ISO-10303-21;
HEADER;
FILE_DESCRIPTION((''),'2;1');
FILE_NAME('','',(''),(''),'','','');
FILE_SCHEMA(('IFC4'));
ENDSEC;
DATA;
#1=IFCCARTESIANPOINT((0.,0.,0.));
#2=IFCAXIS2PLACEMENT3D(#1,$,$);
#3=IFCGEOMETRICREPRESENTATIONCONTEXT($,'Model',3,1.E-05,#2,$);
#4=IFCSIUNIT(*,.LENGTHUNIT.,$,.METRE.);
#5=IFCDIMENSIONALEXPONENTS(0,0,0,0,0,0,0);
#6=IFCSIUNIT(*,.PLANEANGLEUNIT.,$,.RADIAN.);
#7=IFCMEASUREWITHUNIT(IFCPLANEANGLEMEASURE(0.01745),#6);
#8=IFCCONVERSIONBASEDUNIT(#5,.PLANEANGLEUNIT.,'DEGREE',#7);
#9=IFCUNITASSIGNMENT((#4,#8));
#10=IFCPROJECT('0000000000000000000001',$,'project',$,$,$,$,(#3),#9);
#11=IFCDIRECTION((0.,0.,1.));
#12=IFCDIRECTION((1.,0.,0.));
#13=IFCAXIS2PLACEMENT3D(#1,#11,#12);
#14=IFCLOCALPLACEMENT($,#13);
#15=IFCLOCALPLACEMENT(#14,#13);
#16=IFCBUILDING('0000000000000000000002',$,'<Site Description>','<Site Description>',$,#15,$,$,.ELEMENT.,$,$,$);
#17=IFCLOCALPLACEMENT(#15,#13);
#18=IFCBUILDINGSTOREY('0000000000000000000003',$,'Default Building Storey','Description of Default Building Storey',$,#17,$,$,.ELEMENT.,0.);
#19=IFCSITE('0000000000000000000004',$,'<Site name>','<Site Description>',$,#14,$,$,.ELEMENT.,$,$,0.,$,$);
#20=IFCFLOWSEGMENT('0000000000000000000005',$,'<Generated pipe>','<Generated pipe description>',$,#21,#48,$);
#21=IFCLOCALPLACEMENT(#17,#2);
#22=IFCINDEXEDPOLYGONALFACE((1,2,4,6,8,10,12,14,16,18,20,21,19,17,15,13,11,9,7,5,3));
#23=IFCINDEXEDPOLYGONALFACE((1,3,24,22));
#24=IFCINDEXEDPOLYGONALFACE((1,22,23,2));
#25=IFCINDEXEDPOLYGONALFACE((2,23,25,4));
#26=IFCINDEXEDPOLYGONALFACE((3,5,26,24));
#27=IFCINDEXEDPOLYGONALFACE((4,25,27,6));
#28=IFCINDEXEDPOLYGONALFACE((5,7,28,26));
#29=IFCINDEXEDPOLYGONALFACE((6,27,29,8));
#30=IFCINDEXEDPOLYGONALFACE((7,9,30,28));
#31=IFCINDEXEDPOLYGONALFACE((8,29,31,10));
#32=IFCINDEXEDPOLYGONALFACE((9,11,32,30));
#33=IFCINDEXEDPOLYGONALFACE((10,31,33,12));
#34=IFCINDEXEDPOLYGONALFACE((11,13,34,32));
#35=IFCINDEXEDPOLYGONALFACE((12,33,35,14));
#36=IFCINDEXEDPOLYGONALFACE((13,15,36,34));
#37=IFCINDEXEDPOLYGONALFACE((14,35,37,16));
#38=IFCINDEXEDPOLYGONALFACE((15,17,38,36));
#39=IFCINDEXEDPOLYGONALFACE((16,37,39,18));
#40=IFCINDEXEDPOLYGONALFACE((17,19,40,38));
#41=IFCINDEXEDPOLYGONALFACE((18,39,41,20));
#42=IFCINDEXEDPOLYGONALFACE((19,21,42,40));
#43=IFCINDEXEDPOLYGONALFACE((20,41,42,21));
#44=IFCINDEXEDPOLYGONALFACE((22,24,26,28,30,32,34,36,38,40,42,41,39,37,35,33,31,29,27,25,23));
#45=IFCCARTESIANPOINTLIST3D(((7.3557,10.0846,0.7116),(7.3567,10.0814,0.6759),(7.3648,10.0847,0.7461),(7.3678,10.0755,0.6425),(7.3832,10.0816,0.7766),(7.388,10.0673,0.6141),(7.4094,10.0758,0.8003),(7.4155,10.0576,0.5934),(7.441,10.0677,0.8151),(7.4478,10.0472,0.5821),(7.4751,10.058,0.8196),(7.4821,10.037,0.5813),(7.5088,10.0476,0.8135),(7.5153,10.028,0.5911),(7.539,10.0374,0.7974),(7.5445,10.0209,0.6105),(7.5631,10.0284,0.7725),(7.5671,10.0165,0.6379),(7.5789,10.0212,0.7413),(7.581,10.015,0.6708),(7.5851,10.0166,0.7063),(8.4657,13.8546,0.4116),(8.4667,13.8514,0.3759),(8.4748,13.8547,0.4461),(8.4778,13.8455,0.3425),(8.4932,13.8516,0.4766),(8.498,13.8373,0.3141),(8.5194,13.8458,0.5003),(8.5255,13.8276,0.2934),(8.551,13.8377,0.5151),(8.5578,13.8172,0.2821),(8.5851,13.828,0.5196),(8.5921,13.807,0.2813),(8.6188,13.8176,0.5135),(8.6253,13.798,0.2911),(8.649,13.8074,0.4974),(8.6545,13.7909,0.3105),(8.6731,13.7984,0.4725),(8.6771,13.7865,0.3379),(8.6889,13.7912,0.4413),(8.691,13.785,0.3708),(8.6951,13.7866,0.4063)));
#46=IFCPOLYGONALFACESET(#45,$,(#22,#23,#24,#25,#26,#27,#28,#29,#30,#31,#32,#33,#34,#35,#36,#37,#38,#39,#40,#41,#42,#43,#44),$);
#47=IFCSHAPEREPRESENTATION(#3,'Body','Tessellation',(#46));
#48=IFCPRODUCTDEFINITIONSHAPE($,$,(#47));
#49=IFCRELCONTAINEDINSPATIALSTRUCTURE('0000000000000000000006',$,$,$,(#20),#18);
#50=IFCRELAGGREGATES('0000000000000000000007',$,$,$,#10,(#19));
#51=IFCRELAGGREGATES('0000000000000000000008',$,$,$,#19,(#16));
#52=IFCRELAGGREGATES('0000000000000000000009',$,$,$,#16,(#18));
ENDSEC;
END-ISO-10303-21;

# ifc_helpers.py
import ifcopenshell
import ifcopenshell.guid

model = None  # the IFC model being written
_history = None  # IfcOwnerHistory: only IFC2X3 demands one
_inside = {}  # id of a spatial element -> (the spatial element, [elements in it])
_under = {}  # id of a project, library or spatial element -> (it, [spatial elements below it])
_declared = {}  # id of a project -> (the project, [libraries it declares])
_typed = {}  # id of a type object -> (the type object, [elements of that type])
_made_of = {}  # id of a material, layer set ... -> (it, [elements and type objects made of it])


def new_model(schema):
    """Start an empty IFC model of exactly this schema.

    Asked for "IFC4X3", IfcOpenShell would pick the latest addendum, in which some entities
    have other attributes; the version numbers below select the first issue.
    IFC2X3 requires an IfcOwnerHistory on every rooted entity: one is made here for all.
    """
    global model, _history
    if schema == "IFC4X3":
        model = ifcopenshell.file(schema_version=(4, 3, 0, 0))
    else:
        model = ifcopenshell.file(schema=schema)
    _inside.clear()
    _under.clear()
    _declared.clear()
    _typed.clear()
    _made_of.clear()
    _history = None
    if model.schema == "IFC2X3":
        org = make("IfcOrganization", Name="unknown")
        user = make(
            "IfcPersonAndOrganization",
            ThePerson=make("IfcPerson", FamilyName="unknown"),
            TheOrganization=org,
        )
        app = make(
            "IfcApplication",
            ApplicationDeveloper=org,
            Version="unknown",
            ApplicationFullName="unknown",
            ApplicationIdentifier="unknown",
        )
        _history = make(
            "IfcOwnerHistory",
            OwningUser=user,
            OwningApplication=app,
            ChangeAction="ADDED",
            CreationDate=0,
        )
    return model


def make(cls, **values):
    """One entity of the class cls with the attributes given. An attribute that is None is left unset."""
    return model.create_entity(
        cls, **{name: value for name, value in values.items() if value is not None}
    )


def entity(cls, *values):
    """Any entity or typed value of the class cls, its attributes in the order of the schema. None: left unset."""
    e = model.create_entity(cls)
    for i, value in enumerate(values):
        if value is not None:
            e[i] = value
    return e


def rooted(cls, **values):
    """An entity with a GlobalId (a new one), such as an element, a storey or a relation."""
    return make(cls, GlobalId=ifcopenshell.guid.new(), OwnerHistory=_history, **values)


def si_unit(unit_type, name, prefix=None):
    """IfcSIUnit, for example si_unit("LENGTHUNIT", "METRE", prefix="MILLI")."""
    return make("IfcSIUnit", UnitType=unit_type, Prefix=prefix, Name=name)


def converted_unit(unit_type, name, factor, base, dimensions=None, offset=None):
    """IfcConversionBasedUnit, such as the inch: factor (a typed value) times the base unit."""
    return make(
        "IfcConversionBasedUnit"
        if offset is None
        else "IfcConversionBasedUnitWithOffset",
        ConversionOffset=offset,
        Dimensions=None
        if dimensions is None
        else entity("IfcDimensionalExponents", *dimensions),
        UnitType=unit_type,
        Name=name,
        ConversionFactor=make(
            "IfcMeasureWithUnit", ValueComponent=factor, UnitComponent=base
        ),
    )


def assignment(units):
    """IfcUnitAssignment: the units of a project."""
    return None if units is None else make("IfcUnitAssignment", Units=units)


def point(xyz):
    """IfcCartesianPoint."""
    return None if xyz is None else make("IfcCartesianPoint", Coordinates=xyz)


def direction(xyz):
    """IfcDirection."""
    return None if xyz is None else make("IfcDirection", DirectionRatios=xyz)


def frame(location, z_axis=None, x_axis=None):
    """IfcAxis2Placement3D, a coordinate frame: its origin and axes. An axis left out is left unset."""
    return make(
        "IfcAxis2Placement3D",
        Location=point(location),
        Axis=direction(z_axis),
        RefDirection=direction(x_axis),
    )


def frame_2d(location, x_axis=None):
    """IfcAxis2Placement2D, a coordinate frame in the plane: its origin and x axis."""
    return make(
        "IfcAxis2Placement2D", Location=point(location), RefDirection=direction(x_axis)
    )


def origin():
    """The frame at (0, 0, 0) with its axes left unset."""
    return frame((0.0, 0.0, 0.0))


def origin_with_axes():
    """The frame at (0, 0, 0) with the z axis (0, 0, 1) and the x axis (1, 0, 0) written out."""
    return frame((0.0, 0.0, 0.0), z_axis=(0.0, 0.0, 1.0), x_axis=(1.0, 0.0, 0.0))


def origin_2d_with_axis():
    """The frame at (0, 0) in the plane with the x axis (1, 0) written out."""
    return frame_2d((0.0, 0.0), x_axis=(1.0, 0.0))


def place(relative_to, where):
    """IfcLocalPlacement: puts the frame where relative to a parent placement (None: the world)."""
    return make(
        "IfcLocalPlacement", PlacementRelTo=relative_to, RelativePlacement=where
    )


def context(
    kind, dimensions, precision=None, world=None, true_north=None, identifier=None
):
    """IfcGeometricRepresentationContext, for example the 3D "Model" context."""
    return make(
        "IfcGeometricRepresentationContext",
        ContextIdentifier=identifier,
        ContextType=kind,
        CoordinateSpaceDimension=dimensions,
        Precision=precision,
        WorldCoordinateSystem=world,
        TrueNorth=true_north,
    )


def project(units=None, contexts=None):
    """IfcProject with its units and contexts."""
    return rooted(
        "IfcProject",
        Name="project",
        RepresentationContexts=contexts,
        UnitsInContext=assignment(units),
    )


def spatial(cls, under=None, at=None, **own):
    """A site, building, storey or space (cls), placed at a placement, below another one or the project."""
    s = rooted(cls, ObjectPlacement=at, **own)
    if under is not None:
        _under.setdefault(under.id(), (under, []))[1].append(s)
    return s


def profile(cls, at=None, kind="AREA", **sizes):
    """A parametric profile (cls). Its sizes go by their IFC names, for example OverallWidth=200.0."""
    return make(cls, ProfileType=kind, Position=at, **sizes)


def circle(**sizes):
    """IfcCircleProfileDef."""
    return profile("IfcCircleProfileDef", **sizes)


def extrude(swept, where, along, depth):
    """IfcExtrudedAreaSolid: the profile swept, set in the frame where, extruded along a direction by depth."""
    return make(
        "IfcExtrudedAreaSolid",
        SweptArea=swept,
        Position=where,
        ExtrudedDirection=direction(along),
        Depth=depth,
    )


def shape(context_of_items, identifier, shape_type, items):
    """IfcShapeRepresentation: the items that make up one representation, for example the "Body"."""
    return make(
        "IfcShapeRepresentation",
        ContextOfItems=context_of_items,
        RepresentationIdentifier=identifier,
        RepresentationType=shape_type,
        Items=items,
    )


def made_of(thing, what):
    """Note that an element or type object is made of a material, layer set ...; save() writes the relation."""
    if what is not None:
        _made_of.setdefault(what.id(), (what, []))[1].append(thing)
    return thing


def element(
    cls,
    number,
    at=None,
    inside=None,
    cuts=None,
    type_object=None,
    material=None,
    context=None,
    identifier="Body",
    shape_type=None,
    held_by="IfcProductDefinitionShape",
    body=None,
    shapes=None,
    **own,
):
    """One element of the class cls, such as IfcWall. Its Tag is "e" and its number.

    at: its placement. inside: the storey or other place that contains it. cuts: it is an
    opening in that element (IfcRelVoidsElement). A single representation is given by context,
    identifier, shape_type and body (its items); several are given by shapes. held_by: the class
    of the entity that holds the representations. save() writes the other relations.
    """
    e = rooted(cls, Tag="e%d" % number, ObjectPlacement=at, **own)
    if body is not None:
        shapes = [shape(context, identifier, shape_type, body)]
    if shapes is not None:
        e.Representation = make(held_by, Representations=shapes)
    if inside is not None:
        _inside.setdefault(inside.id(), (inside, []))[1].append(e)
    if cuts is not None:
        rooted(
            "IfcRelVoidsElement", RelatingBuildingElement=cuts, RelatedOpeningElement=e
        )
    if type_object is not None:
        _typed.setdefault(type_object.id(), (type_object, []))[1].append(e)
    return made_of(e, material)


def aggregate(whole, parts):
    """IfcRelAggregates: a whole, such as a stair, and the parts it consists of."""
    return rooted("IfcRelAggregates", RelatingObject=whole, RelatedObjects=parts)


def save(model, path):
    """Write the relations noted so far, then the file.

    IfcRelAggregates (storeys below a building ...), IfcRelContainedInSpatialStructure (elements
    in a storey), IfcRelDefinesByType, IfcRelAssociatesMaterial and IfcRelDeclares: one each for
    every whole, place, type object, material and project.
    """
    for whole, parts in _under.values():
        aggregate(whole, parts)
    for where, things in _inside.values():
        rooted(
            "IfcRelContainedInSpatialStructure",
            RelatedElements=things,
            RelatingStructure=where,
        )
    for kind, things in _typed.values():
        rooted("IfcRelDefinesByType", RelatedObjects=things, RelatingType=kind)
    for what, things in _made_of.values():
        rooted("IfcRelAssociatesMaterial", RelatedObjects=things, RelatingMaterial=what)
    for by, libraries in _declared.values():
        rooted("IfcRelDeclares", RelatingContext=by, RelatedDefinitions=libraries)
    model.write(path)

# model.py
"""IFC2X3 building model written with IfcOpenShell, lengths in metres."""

from ifc_helpers import new_model, entity, si_unit, converted_unit, frame, origin, origin_with_axes, origin_2d_with_axis, place, context, project, spatial, circle, extrude, element, save


model = new_model("IFC2X3")

# Units and contexts
model_context = context("Model", 3, precision=1e-05, world=origin())
ifc_project = project(units=[si_unit("LENGTHUNIT", "METRE"), converted_unit("PLANEANGLEUNIT", "DEGREE", entity("IfcPlaneAngleMeasure", 0.01745), si_unit("PLANEANGLEUNIT", "RADIAN"), dimensions=[0, 0, 0, 0, 0, 0, 0])], contexts=[model_context])

# Site, building, storey
site_placement = place(None, origin_with_axes())
site = spatial("IfcSite", under=ifc_project, at=site_placement, Name="<Site name>", Description="<Site Description>", CompositionType="ELEMENT", RefElevation=0.0)
building_placement = place(site_placement, origin_with_axes())
building = spatial("IfcBuilding", under=site, at=building_placement, Name="<Site Description>", Description="<Site Description>", CompositionType="ELEMENT")
storey_placement = place(building_placement, origin_with_axes())
storey = spatial("IfcBuildingStorey", under=building, at=storey_placement, Name="Default Building Storey", Description="Description of Default Building Storey", CompositionType="ELEMENT", Elevation=0.0)

# Flow segment
flow_segment_1_placement = place(storey_placement, frame((8.58, 13.82, 0.4), z_axis=(-0.281623, -0.956502, 0.076114), x_axis=(0.042532, 0.066803, 0.996859)))
element("IfcFlowSegment", 1, at=flow_segment_1_placement, inside=storey, Name="<Generated pipe>", Description="<Generated pipe description>", context=model_context, shape_type="SweptSolid", body=[
    extrude(circle(Radius=0.12, at=origin_2d_with_axis()), origin_with_axes(), (0.0, 0.0, 1.0), 3.9414),
])

save(model, "model.ifc")
